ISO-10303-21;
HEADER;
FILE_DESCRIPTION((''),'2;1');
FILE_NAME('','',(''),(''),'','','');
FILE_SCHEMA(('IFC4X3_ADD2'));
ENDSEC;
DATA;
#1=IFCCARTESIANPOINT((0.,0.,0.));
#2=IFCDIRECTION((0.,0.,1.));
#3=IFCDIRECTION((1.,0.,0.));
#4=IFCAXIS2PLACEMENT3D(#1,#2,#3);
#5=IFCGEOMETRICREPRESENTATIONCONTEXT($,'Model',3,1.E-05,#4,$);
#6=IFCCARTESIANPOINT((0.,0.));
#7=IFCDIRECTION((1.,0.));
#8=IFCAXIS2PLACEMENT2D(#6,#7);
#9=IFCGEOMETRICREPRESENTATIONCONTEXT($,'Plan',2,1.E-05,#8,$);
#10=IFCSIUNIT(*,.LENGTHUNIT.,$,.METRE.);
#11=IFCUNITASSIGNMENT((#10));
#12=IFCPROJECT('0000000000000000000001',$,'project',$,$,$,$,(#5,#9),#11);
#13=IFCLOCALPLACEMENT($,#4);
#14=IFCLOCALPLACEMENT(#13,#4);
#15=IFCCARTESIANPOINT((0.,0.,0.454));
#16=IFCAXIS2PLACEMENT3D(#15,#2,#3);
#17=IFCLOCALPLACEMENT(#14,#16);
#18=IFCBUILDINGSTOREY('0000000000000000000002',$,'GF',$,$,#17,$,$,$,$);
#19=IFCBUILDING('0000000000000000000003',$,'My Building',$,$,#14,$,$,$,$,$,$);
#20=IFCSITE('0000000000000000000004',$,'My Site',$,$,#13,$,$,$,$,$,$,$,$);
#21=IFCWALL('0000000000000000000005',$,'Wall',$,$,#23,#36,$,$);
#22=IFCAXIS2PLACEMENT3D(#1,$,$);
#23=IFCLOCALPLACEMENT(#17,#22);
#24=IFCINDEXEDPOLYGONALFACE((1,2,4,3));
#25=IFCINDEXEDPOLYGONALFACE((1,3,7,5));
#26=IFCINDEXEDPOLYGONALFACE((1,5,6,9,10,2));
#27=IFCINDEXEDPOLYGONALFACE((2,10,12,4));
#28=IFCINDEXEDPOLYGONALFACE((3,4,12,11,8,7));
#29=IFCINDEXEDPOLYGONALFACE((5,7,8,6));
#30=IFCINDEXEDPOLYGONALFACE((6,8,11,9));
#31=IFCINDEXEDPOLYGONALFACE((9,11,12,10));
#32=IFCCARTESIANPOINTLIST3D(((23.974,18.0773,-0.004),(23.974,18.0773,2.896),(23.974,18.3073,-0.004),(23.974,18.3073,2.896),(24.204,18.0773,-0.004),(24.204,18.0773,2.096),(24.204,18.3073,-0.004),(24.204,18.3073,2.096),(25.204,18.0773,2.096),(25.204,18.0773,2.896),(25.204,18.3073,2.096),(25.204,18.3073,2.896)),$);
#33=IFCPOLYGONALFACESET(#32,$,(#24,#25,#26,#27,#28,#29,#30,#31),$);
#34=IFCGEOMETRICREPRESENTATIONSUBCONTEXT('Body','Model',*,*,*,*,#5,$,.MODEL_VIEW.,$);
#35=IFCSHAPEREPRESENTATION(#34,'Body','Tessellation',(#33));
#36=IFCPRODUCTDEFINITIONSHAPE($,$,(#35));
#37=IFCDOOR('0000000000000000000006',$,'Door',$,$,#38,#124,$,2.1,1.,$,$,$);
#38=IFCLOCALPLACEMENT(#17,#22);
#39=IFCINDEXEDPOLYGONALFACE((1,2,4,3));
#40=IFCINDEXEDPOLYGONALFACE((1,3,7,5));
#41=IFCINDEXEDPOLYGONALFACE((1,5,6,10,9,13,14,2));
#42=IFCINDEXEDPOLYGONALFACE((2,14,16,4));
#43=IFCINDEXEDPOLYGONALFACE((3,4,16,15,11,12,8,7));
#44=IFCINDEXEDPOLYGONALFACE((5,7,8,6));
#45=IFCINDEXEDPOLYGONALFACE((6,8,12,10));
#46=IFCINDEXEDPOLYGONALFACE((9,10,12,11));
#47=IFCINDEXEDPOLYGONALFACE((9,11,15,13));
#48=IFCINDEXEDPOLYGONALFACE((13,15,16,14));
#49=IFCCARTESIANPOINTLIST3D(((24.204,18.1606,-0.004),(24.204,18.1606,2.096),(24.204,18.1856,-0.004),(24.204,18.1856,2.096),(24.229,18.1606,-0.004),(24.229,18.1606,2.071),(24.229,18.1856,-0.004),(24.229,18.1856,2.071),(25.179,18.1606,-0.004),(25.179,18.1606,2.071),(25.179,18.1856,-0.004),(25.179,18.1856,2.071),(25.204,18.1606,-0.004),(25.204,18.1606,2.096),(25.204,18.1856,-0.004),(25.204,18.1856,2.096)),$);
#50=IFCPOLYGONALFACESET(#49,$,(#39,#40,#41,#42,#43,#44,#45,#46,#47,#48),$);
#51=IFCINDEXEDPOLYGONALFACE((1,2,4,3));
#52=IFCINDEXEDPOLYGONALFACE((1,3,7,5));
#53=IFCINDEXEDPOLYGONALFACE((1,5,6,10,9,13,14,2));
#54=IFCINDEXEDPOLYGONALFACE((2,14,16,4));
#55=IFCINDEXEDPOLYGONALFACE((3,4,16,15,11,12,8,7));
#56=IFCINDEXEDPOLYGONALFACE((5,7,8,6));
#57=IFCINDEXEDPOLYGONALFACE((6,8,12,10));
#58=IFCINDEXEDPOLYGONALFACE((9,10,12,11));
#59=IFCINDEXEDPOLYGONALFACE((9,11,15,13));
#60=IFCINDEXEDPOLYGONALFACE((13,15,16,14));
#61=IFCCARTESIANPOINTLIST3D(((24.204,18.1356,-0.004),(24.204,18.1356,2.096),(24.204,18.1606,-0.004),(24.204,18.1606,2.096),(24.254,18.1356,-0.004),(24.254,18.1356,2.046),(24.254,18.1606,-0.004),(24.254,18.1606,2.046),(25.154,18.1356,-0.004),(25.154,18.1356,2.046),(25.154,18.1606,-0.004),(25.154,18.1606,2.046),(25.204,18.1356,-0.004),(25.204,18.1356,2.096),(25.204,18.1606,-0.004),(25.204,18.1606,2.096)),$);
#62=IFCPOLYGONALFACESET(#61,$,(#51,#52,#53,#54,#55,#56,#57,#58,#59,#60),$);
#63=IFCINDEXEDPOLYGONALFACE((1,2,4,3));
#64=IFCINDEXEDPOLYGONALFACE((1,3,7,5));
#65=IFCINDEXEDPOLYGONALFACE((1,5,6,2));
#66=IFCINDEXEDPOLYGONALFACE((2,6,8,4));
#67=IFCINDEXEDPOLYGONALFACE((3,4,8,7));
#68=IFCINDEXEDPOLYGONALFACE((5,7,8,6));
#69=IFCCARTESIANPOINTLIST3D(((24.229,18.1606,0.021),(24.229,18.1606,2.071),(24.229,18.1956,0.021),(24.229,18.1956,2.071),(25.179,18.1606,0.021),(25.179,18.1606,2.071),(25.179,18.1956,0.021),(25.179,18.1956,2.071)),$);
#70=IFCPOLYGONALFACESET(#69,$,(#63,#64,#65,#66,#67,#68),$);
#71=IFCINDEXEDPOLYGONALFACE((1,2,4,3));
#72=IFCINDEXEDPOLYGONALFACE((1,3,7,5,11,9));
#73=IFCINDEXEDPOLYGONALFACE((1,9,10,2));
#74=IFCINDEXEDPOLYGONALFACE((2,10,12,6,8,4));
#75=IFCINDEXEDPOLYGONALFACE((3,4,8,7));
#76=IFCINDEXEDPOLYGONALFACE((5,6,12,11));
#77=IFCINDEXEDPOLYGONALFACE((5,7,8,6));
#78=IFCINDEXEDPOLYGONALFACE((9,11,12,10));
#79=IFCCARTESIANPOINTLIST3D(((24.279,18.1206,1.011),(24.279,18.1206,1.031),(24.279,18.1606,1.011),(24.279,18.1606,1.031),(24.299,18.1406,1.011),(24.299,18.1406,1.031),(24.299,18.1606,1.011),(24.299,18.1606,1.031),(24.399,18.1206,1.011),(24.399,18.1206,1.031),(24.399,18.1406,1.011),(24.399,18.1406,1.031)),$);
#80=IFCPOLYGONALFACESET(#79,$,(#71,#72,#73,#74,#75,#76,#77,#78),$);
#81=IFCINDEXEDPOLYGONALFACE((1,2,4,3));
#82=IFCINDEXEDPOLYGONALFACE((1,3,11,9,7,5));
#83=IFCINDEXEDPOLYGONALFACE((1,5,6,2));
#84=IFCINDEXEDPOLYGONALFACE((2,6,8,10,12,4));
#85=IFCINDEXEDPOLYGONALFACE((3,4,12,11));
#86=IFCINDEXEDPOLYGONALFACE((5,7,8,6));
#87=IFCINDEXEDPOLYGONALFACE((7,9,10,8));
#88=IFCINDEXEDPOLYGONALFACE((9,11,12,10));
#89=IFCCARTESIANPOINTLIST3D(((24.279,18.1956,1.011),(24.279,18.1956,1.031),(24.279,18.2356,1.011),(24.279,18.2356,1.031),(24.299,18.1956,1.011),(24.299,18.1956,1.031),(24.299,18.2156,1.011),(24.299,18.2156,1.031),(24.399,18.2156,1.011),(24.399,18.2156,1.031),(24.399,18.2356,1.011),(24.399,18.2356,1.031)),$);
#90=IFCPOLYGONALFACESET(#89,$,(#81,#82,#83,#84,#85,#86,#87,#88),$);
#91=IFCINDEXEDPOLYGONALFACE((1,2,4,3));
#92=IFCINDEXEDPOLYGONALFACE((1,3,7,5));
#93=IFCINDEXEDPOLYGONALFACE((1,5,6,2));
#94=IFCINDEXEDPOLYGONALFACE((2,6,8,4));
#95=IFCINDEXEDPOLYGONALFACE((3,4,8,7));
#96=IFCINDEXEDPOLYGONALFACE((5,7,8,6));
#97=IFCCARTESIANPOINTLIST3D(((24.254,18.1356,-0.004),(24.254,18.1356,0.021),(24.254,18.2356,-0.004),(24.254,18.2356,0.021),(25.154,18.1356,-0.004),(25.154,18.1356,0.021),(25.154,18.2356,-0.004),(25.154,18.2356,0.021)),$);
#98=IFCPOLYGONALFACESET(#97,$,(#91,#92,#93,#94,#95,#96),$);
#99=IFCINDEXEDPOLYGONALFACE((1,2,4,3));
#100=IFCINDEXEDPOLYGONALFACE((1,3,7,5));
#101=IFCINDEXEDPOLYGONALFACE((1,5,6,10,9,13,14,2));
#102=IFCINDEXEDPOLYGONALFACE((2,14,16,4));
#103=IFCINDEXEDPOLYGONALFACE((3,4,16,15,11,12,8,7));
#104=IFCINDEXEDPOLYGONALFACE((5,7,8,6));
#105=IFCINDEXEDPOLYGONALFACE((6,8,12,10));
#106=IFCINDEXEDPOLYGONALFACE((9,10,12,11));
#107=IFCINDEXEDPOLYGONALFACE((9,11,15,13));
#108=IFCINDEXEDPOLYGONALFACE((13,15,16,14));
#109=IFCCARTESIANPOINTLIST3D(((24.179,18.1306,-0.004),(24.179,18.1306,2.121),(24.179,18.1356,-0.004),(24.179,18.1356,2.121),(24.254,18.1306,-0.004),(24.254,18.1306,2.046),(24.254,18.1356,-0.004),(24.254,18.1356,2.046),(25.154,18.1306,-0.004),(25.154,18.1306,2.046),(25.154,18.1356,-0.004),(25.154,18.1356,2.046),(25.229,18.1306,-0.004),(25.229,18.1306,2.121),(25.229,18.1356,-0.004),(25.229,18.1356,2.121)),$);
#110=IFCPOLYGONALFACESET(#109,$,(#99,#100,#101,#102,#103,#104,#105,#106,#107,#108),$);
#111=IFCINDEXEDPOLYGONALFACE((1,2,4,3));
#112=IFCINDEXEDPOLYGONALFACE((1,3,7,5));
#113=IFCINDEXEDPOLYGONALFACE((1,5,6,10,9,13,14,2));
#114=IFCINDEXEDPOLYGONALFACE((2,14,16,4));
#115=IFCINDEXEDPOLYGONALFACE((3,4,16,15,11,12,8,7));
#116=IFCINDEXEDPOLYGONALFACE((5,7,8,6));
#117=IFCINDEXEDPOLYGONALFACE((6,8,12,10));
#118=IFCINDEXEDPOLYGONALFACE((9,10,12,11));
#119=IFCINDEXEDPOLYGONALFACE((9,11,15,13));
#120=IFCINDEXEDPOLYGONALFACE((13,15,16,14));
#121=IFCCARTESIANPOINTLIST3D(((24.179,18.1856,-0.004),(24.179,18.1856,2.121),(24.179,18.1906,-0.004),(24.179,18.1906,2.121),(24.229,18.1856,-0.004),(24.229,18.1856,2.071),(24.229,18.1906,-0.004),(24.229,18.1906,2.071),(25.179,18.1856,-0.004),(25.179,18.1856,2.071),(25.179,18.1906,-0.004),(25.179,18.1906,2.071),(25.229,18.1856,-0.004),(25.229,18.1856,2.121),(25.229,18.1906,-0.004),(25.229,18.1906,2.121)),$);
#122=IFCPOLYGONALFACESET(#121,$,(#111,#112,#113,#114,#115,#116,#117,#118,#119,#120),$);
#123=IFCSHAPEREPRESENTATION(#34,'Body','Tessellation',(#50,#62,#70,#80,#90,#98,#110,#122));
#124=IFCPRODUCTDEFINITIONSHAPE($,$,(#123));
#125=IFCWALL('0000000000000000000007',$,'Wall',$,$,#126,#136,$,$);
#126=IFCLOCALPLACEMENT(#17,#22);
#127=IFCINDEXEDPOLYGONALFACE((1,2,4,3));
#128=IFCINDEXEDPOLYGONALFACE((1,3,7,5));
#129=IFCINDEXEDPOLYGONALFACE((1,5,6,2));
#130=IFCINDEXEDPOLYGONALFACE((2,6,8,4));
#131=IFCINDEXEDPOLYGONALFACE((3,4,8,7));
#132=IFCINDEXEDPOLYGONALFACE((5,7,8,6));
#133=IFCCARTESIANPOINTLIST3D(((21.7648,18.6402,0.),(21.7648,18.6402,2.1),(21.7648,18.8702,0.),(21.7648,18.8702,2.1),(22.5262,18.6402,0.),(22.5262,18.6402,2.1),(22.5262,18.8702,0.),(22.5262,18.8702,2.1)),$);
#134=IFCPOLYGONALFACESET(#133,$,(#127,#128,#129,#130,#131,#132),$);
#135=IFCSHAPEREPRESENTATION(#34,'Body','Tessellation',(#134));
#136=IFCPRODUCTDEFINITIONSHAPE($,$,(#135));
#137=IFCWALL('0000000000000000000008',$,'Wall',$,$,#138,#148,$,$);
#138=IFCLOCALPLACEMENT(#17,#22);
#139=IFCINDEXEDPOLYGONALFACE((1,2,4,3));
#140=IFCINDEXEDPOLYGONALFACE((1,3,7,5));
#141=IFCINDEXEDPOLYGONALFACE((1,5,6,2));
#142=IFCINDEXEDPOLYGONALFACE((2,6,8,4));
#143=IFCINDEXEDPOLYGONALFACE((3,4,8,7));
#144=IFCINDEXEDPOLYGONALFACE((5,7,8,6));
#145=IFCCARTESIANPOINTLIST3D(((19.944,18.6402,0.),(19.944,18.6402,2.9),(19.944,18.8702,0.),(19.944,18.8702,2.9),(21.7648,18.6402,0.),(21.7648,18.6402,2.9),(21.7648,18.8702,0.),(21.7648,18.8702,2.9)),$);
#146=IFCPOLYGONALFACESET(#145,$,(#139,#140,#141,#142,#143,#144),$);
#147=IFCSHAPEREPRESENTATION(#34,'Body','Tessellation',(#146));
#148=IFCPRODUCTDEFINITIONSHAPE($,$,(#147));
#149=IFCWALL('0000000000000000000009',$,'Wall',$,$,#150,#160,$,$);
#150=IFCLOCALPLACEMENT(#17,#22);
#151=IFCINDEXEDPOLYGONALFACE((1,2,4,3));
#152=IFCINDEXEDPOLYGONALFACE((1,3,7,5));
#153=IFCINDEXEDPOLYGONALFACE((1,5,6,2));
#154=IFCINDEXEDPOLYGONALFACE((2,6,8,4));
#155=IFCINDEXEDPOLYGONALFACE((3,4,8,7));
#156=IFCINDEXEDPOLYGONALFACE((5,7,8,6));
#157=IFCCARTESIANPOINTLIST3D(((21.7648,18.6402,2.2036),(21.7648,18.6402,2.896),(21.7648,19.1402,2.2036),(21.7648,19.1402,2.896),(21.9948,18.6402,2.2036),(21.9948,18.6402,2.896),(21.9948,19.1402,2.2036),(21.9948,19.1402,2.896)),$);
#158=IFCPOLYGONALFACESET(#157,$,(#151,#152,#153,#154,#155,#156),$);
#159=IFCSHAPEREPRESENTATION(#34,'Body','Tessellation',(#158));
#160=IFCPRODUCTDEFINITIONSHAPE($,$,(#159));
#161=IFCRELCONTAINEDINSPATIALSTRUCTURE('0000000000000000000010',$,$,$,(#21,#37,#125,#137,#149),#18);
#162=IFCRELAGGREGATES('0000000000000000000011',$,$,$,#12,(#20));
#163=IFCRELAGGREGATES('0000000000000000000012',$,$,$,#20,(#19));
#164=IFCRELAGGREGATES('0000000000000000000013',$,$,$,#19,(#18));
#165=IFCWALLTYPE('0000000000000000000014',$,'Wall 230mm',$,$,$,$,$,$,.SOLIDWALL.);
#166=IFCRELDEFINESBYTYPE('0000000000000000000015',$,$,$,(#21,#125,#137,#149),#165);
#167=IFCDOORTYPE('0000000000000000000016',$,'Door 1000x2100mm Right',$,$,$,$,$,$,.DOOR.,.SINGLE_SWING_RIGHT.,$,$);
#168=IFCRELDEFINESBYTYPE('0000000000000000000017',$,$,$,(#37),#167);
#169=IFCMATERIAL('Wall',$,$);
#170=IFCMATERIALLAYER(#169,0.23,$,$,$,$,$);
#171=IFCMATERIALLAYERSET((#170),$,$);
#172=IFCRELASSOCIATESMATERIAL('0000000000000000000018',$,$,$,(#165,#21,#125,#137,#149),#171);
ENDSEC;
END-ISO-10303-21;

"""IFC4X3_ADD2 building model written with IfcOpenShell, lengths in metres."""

from ifc_helpers import new_model, entity, si_unit, frame, origin_with_axes, origin_2d_with_axis, place, context, subcontext, project, spatial, line, indexed_curve, outline, extrude, clip, halfspace, shape, source, transform, mapped, material, layer, layer_set, layer_usage, type_object, type_shapes, element, fill, save


model = new_model("IFC4X3_ADD2")

# Units and contexts
model_context = context("Model", 3, precision=1e-05, world=origin_with_axes())
plan_context = context("Plan", 2, precision=1e-05, world=origin_2d_with_axis())
body_context_1 = subcontext(model_context, "Body", "Model", "MODEL_VIEW")
body_context_2 = subcontext(plan_context, "Body", "Plan", "PLAN_VIEW")
ifc_project = project(units=[si_unit("LENGTHUNIT", "METRE")], contexts=[model_context, plan_context])

# Site, building, storey
site_placement = place(None, origin_with_axes())
site = spatial("IfcSite", under=ifc_project, at=site_placement, Name="My Site")
building_placement = place(site_placement, origin_with_axes())
building = spatial("IfcBuilding", under=site, at=building_placement, Name="My Building")
storey_placement = place(building_placement, frame((0.0, 0.0, 0.454), z_axis=(0.0, 0.0, 1.0), x_axis=(1.0, 0.0, 0.0)))
storey = spatial("IfcBuildingStorey", under=building, at=storey_placement, Name="GF")

# Shared definitions
ifc_material_1 = material(Name="Wall")

# Shared definitions
ifc_layer_1 = layer(ifc_material_1, 0.23)
ifc_layer_set_1 = layer_set([ifc_layer_1])
wall_type_1 = type_object("IfcWallType", Name="Wall 230mm", PredefinedType="SOLIDWALL", material=ifc_layer_set_1)

# Shared definitions
shared_shape_1 = source(origin_with_axes(), body_context_1, "Body", "SweptSolid", [
    extrude(outline(indexed_curve([(0.0, 0.0), (1.0, 0.0), (1.0, 2.1), (0.0, 2.1)], segments=[line(1, 2, 3, 4, 1)])), frame((0.0, -0.6, 0.0), z_axis=(0.0, -1.0, 0.0), x_axis=(1.0, 0.0, 0.0)), (0.0, 0.0, -1.0), 1.2),
])
door_type_1 = type_object("IfcDoorType", Name="Door 1000x2100mm Right", OperationType="SINGLE_SWING_RIGHT", PredefinedType="DOOR")
shared_shape_2 = source(origin_with_axes(), body_context_1, "Body", "SweptSolid", [
    extrude(outline(indexed_curve([(0.0, 0.0), (0.0, 2.1), (1.0, 2.1), (1.0, 0.0), (0.975, 0.0), (0.975, 2.075), (0.025, 2.075), (0.025, 0.0)], segments=[line(1, 2, 3, 4, 5, 6, 7, 8, 1)])), frame((0.0, 0.025, 0.0), z_axis=(0.0, -1.0, 0.0), x_axis=(1.0, 0.0, 0.0)), (0.0, 0.0, -1.0), 0.025),
    extrude(outline(indexed_curve([(0.0, 0.0), (0.0, 2.1), (1.0, 2.1), (1.0, 0.0), (0.95, 0.0), (0.95, 2.05), (0.05, 2.05), (0.05, 0.0)], segments=[line(1, 2, 3, 4, 5, 6, 7, 8, 1)])), frame((0.0, 0.0, 0.0), z_axis=(0.0, -1.0, 0.0), x_axis=(1.0, 0.0, 0.0)), (0.0, 0.0, -1.0), 0.025),
    extrude(outline(indexed_curve([(0.0, 0.0), (0.95, 0.0), (0.95, 0.035), (0.0, 0.035)], segments=[line(1, 2, 3, 4, 1)])), frame((0.025, 0.025, 0.025), z_axis=(0.0, 0.0, 1.0), x_axis=(1.0, 0.0, 0.0)), (0.0, 0.0, 1.0), 2.05),
    extrude(outline(indexed_curve([(0.0, 0.0), (0.0, -0.04), (0.12, -0.04), (0.12, -0.02), (0.02, -0.02), (0.02, 0.0)], segments=[line(1, 2, 3, 4, 5, 6, 1)])), frame((0.075, 0.025, 1.015), z_axis=(0.0, 0.0, 1.0), x_axis=(1.0, 0.0, 0.0)), (0.0, 0.0, 1.0), 0.02),
    extrude(outline(indexed_curve([(0.0, 0.0), (0.0, 0.04), (0.12, 0.04), (0.12, 0.02), (0.02, 0.02), (0.02, 0.0)], segments=[line(1, 2, 3, 4, 5, 6, 1)])), frame((0.075, 0.06, 1.015), z_axis=(0.0, 0.0, 1.0), x_axis=(1.0, 0.0, 0.0)), (0.0, 0.0, 1.0), 0.02),
    extrude(outline(indexed_curve([(0.0, 0.0), (0.9, 0.0), (0.9, 0.1), (0.0, 0.1)], segments=[line(1, 2, 3, 4, 1)])), frame((0.05, 0.0, 0.0), z_axis=(0.0, 0.0, 1.0), x_axis=(1.0, 0.0, 0.0)), (0.0, 0.0, 1.0), 0.025),
    extrude(outline(indexed_curve([(0.0, 0.0), (0.0, 2.125), (1.05, 2.125), (1.05, 0.0), (0.975, 0.0), (0.975, 2.05), (0.075, 2.05), (0.075, 0.0)], segments=[line(1, 2, 3, 4, 5, 6, 7, 8, 1)])), frame((-0.025, -0.005, 0.0), z_axis=(0.0, -1.0, 0.0), x_axis=(1.0, 0.0, 0.0)), (0.0, 0.0, -1.0), 0.005),
    extrude(outline(indexed_curve([(0.0, 0.0), (0.0, 2.125), (1.05, 2.125), (1.05, 0.0), (1.0, 0.0), (1.0, 2.075), (0.05, 2.075), (0.05, 0.0)], segments=[line(1, 2, 3, 4, 5, 6, 7, 8, 1)])), frame((-0.025, 0.05, 0.0), z_axis=(0.0, -1.0, 0.0), x_axis=(1.0, 0.0, 0.0)), (0.0, 0.0, -1.0), 0.005),
])
shared_shape_3 = source(origin_with_axes(), body_context_2, "Body", "Curve2D", [
    entity("IfcIndexedPolyCurve", entity("IfcCartesianPointList2D", [[0.0, 0.0], [0.0, 0.05], [0.025, 0.05], [0.025, 0.025], [0.05, 0.025], [0.05, 0.0]]), [entity("IfcLineIndex", [1, 2, 3, 4, 5, 6, 1])]),
    entity("IfcIndexedPolyCurve", entity("IfcCartesianPointList2D", [[1.0, 0.0], [1.0, 0.05], [0.975, 0.05], [0.975, 0.025], [0.95, 0.025], [0.95, 0.0]]), [entity("IfcLineIndex", [1, 2, 3, 4, 5, 6, 1])]),
    entity("IfcTrimmedCurve", entity("IfcEllipse", entity("IfcAxis2Placement2D", entity("IfcCartesianPoint", [0.94, 0.05]), entity("IfcDirection", [1.0, 0.0])), 0.915, 0.95), [entity("IfcCartesianPoint", [0.94, 1.0])], [entity("IfcCartesianPoint", [0.025, 0.05])], True, "CARTESIAN"),
    entity("IfcIndexedPolyCurve", entity("IfcCartesianPointList2D", [[0.975, 0.05], [0.94, 0.05], [0.94, 1.0], [0.975, 1.0]]), [entity("IfcLineIndex", [1, 2, 3, 4, 1])]),
])
type_shapes(door_type_1, [shared_shape_2, shared_shape_3])

# Wall, opening, door
ifc_layer_usage_1 = layer_usage(ifc_layer_set_1, "AXIS2", "POSITIVE", 0.0)
wall_1_placement = place(storey_placement, frame((25.204, 18.3073, -0.004), z_axis=(0.0, 0.0, 1.0), x_axis=(-1.0, 0.0, 0.0)))
wall_1 = element("IfcWall", 1, at=wall_1_placement, inside=storey, type_object=wall_type_1, material=ifc_layer_usage_1, Name="Wall", context=body_context_1, shape_type="SweptSolid", body=[
    extrude(outline(indexed_curve([(0.0, 0.0), (0.0, 0.23), (1.23, 0.23), (1.23, 0.0), (0.0, 0.0)], self_intersect=False)), origin_with_axes(), (0.0, 0.0, 1.0), 2.9),
])
opening_1_placement = place(wall_1_placement, frame((0.0, 0.0, 0.0), z_axis=(0.0, 0.0, 1.0), x_axis=(1.0, 0.0, 0.0)))
opening_1 = element("IfcOpeningElement", 2, at=opening_1_placement, cuts=wall_1, PredefinedType="OPENING", context=body_context_1, shape_type="MappedRepresentation", body=[
    mapped(shared_shape_1, transform((0.0, 0.0, 0.0), x_axis=(1.0, 0.0, 0.0), y_axis=(0.0, 1.0, 0.0), z_axis=(0.0, 0.0, 1.0), scale=1.0)),
])
door_1_placement = place(opening_1_placement, frame((1.0, 0.1717, 0.0), z_axis=(0.0, 0.0, 1.0), x_axis=(-1.0, 0.0, 0.0)))
door_1 = element("IfcDoor", 3, at=door_1_placement, inside=storey, type_object=door_type_1, Name="Door", OverallHeight=2.1, OverallWidth=1.0, shapes=[
    shape(body_context_1, "Body", "MappedRepresentation", [mapped(shared_shape_2, transform((0.0, 0.0, 0.0), x_axis=(1.0, 0.0, 0.0), y_axis=(0.0, 1.0, 0.0), z_axis=(0.0, 0.0, 1.0), scale=1.0))]),
    shape(body_context_2, "Body", "MappedRepresentation", [mapped(shared_shape_3, transform((0.0, 0.0, 0.0), x_axis=(1.0, 0.0, 0.0), y_axis=(0.0, 1.0, 0.0), z_axis=(0.0, 0.0, 1.0), scale=1.0))]),
])
fill(opening_1, door_1)

# Walls
ifc_layer_usage_2 = layer_usage(ifc_layer_set_1, "AXIS2", "POSITIVE", 0.0)
wall_2_placement = place(storey_placement, frame((21.7648, 18.6402, 0.0), z_axis=(0.0, 0.0, 1.0), x_axis=(1.0, -0.000001, 0.0)))
element("IfcWall", 4, at=wall_2_placement, inside=storey, type_object=wall_type_1, material=ifc_layer_usage_2, Name="Wall", context=body_context_1, shape_type="Clipping", body=[
    clip(extrude(outline(indexed_curve([(0.0, 0.0), (0.0, 0.23), (0.7614, 0.23), (0.7614, 0.0), (0.0, 0.0)], self_intersect=False)), origin_with_axes(), (0.0, 0.0, 1.0), 2.554), halfspace(frame((0.0, 0.0, 2.1), z_axis=(0.0, 0.0, 1.0), x_axis=(-1.0, 0.0, 0.0)), False)),
])
ifc_layer_usage_3 = layer_usage(ifc_layer_set_1, "AXIS2", "POSITIVE", 0.0)
wall_3_placement = place(storey_placement, frame((19.944, 18.6402, 0.0), z_axis=(0.0, 0.0, 1.0), x_axis=(1.0, -0.000001, 0.0)))
element("IfcWall", 5, at=wall_3_placement, inside=storey, type_object=wall_type_1, material=ifc_layer_usage_3, Name="Wall", context=body_context_1, shape_type="SweptSolid", body=[
    extrude(outline(indexed_curve([(0.0, 0.0), (0.0, 0.23), (1.8208, 0.23), (1.8208, 0.0), (0.0, 0.0)], self_intersect=False)), origin_with_axes(), (0.0, 0.0, 1.0), 2.9),
])
ifc_layer_usage_4 = layer_usage(ifc_layer_set_1, "AXIS2", "POSITIVE", 0.0)
wall_4_placement = place(storey_placement, frame((21.9948, 18.6402, 2.2036), z_axis=(0.0, 0.0, 1.0), x_axis=(0.000001, 1.0, 0.0)))
element("IfcWall", 6, at=wall_4_placement, inside=storey, type_object=wall_type_1, material=ifc_layer_usage_4, Name="Wall", context=body_context_1, shape_type="Clipping", body=[
    clip(extrude(outline(indexed_curve([(0.0, 0.0), (0.0, 0.23), (0.5, 0.23), (0.5, 0.0), (0.0, 0.0)], self_intersect=False)), origin_with_axes(), (0.0, 0.0, 1.0), 3.35), halfspace(frame((0.0, 0.0, 0.6924), z_axis=(0.0, 0.0, 1.0), x_axis=(-1.0, 0.0, 0.0)), False)),
])

save(model, "model.ifc")
